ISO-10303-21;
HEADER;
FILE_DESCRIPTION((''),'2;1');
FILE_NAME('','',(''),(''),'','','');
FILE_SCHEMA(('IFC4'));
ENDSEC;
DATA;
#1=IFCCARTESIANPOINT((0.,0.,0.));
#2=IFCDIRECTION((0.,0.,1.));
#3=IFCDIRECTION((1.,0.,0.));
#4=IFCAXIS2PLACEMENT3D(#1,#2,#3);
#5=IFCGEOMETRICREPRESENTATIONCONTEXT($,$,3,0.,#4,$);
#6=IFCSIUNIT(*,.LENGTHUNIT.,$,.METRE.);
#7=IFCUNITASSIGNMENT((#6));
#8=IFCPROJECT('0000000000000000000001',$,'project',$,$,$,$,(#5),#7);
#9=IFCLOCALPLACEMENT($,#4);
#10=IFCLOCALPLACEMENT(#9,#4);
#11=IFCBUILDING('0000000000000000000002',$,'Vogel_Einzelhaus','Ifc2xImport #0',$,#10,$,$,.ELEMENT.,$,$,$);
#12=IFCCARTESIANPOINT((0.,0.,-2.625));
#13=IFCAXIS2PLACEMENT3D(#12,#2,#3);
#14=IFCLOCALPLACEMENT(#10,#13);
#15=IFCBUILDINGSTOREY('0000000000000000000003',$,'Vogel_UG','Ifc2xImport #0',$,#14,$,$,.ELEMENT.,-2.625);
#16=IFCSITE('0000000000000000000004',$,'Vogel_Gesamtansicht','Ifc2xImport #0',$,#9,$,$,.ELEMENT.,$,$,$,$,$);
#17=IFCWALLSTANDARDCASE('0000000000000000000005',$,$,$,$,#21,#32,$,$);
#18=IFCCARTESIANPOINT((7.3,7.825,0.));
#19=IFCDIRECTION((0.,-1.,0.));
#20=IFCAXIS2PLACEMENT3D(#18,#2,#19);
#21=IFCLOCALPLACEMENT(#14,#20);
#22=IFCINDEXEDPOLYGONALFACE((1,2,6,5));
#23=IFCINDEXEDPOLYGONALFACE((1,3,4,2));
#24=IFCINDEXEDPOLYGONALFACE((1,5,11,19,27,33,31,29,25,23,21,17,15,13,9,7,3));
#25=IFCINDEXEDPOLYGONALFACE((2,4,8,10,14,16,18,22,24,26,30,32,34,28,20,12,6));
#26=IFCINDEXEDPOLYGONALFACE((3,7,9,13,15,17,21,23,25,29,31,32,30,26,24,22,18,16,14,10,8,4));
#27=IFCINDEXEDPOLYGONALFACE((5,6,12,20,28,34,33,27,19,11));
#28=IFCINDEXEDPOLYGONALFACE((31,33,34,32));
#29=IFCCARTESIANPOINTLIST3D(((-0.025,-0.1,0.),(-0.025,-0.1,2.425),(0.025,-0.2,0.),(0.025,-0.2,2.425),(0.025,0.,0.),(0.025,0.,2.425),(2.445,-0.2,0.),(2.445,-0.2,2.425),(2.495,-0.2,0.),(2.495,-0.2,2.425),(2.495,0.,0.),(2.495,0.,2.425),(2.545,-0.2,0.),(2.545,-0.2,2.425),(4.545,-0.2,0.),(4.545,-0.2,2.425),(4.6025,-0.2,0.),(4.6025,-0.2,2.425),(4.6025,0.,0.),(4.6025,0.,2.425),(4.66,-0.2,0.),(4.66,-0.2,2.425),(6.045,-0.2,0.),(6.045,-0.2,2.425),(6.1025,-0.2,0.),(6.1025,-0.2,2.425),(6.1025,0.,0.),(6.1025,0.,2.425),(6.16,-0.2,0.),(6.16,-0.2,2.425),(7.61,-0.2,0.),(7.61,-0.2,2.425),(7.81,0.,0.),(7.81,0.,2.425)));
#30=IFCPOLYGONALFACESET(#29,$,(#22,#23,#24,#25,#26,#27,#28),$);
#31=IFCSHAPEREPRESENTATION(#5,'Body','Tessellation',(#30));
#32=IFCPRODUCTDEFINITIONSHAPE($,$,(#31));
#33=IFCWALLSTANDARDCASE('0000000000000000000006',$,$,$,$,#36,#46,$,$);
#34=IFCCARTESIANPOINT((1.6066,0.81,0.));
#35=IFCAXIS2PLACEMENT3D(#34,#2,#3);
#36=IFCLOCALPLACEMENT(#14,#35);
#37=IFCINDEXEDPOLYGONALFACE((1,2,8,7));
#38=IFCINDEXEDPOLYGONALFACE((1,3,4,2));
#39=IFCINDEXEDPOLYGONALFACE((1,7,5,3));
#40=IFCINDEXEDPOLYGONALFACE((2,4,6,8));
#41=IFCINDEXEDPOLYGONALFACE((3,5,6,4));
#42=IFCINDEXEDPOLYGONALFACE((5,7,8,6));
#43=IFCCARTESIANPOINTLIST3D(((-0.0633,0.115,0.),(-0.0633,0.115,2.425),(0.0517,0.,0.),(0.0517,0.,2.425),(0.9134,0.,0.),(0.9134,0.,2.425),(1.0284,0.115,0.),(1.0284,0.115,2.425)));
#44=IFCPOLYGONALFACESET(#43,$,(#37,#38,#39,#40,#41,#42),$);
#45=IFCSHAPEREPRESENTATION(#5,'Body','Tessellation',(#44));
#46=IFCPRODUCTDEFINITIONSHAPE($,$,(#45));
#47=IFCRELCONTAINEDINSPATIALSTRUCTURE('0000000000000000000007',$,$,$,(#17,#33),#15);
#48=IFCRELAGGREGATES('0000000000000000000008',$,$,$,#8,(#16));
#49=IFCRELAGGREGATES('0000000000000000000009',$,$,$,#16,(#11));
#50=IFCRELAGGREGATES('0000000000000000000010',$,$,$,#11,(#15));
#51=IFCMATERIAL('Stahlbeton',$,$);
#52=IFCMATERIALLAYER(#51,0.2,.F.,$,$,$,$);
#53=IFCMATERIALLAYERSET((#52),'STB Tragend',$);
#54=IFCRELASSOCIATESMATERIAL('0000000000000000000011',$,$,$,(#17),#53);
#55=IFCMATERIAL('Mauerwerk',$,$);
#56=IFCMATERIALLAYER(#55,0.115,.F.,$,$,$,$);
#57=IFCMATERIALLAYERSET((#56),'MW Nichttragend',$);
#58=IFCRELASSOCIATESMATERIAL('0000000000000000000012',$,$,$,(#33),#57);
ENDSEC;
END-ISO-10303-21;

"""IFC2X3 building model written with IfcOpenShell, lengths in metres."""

from ifc_helpers import new_model, si_unit, frame, origin_with_axes, place, context, project, spatial, polyline, outline, extrude, material, layer, layer_set, layer_usage, element, save


model = new_model("IFC2X3")

# Units and contexts
context_of_model = context(None, 3, precision=0.0, world=origin_with_axes())
ifc_project = project(units=[si_unit("LENGTHUNIT", "METRE")], contexts=[context_of_model])

# Site, building, storey
site_placement = place(None, origin_with_axes())
site = spatial("IfcSite", under=ifc_project, at=site_placement, Name="Vogel_Gesamtansicht", Description="Ifc2xImport #0", CompositionType="ELEMENT")
building_placement = place(site_placement, origin_with_axes())
building = spatial("IfcBuilding", under=site, at=building_placement, Name="Vogel_Einzelhaus", Description="Ifc2xImport #0", CompositionType="ELEMENT")
storey_placement = place(building_placement, frame((0.0, 0.0, -2.625), z_axis=(0.0, 0.0, 1.0), x_axis=(1.0, 0.0, 0.0)))
storey = spatial("IfcBuildingStorey", under=building, at=storey_placement, Name="Vogel_UG", Description="Ifc2xImport #0", CompositionType="ELEMENT", Elevation=-2.625)

# Wall
ifc_material_1 = material(Name="Stahlbeton")
ifc_layer_1 = layer(ifc_material_1, 0.2, ventilated=False)
ifc_layer_set_1 = layer_set([ifc_layer_1], Name="STB Tragend")
ifc_layer_usage_1 = layer_usage(ifc_layer_set_1, "AXIS2", "POSITIVE", -0.2)
wall_1_placement = place(storey_placement, frame((7.3, 7.825, 0.0), z_axis=(0.0, 0.0, 1.0), x_axis=(0.0, -1.0, 0.0)))
element("IfcWallStandardCase", 1, at=wall_1_placement, inside=storey, material=ifc_layer_usage_1, context=context_of_model, shape_type="SweptSolid", body=[
    extrude(outline(polyline([(0.025, 0.0), (-0.025, -0.1), (0.025, -0.2), (2.445, -0.2), (2.495, -0.2), (2.545, -0.2), (4.545, -0.2), (4.6025, -0.2), (4.66, -0.2), (6.045, -0.2), (6.1025, -0.2), (6.16, -0.2), (7.61, -0.2), (7.81, 0.0), (6.1025, 0.0), (4.6025, 0.0), (2.495, 0.0), (0.025, 0.0)])), origin_with_axes(), (0.0, 0.0, 1.0), 2.425),
])

# Shared definitions
ifc_material_2 = material(Name="Mauerwerk")
ifc_layer_2 = layer(ifc_material_2, 0.115, ventilated=False)
ifc_layer_set_2 = layer_set([ifc_layer_2], Name="MW Nichttragend")

# Wall
ifc_layer_usage_2 = layer_usage(ifc_layer_set_2, "AXIS2", "POSITIVE", 0.0)
wall_2_placement = place(storey_placement, frame((1.6066, 0.81, 0.0), z_axis=(0.0, 0.0, 1.0), x_axis=(1.0, 0.0, 0.0)))
element("IfcWallStandardCase", 2, at=wall_2_placement, inside=storey, material=ifc_layer_usage_2, context=context_of_model, shape_type="SweptSolid", body=[
    extrude(outline(polyline([(-0.0633, 0.115), (0.0517, 0.0), (0.9134, 0.0), (1.0284, 0.115), (-0.0633, 0.115)])), origin_with_axes(), (0.0, 0.0, 1.0), 2.425),
])

save(model, "model.ifc")
